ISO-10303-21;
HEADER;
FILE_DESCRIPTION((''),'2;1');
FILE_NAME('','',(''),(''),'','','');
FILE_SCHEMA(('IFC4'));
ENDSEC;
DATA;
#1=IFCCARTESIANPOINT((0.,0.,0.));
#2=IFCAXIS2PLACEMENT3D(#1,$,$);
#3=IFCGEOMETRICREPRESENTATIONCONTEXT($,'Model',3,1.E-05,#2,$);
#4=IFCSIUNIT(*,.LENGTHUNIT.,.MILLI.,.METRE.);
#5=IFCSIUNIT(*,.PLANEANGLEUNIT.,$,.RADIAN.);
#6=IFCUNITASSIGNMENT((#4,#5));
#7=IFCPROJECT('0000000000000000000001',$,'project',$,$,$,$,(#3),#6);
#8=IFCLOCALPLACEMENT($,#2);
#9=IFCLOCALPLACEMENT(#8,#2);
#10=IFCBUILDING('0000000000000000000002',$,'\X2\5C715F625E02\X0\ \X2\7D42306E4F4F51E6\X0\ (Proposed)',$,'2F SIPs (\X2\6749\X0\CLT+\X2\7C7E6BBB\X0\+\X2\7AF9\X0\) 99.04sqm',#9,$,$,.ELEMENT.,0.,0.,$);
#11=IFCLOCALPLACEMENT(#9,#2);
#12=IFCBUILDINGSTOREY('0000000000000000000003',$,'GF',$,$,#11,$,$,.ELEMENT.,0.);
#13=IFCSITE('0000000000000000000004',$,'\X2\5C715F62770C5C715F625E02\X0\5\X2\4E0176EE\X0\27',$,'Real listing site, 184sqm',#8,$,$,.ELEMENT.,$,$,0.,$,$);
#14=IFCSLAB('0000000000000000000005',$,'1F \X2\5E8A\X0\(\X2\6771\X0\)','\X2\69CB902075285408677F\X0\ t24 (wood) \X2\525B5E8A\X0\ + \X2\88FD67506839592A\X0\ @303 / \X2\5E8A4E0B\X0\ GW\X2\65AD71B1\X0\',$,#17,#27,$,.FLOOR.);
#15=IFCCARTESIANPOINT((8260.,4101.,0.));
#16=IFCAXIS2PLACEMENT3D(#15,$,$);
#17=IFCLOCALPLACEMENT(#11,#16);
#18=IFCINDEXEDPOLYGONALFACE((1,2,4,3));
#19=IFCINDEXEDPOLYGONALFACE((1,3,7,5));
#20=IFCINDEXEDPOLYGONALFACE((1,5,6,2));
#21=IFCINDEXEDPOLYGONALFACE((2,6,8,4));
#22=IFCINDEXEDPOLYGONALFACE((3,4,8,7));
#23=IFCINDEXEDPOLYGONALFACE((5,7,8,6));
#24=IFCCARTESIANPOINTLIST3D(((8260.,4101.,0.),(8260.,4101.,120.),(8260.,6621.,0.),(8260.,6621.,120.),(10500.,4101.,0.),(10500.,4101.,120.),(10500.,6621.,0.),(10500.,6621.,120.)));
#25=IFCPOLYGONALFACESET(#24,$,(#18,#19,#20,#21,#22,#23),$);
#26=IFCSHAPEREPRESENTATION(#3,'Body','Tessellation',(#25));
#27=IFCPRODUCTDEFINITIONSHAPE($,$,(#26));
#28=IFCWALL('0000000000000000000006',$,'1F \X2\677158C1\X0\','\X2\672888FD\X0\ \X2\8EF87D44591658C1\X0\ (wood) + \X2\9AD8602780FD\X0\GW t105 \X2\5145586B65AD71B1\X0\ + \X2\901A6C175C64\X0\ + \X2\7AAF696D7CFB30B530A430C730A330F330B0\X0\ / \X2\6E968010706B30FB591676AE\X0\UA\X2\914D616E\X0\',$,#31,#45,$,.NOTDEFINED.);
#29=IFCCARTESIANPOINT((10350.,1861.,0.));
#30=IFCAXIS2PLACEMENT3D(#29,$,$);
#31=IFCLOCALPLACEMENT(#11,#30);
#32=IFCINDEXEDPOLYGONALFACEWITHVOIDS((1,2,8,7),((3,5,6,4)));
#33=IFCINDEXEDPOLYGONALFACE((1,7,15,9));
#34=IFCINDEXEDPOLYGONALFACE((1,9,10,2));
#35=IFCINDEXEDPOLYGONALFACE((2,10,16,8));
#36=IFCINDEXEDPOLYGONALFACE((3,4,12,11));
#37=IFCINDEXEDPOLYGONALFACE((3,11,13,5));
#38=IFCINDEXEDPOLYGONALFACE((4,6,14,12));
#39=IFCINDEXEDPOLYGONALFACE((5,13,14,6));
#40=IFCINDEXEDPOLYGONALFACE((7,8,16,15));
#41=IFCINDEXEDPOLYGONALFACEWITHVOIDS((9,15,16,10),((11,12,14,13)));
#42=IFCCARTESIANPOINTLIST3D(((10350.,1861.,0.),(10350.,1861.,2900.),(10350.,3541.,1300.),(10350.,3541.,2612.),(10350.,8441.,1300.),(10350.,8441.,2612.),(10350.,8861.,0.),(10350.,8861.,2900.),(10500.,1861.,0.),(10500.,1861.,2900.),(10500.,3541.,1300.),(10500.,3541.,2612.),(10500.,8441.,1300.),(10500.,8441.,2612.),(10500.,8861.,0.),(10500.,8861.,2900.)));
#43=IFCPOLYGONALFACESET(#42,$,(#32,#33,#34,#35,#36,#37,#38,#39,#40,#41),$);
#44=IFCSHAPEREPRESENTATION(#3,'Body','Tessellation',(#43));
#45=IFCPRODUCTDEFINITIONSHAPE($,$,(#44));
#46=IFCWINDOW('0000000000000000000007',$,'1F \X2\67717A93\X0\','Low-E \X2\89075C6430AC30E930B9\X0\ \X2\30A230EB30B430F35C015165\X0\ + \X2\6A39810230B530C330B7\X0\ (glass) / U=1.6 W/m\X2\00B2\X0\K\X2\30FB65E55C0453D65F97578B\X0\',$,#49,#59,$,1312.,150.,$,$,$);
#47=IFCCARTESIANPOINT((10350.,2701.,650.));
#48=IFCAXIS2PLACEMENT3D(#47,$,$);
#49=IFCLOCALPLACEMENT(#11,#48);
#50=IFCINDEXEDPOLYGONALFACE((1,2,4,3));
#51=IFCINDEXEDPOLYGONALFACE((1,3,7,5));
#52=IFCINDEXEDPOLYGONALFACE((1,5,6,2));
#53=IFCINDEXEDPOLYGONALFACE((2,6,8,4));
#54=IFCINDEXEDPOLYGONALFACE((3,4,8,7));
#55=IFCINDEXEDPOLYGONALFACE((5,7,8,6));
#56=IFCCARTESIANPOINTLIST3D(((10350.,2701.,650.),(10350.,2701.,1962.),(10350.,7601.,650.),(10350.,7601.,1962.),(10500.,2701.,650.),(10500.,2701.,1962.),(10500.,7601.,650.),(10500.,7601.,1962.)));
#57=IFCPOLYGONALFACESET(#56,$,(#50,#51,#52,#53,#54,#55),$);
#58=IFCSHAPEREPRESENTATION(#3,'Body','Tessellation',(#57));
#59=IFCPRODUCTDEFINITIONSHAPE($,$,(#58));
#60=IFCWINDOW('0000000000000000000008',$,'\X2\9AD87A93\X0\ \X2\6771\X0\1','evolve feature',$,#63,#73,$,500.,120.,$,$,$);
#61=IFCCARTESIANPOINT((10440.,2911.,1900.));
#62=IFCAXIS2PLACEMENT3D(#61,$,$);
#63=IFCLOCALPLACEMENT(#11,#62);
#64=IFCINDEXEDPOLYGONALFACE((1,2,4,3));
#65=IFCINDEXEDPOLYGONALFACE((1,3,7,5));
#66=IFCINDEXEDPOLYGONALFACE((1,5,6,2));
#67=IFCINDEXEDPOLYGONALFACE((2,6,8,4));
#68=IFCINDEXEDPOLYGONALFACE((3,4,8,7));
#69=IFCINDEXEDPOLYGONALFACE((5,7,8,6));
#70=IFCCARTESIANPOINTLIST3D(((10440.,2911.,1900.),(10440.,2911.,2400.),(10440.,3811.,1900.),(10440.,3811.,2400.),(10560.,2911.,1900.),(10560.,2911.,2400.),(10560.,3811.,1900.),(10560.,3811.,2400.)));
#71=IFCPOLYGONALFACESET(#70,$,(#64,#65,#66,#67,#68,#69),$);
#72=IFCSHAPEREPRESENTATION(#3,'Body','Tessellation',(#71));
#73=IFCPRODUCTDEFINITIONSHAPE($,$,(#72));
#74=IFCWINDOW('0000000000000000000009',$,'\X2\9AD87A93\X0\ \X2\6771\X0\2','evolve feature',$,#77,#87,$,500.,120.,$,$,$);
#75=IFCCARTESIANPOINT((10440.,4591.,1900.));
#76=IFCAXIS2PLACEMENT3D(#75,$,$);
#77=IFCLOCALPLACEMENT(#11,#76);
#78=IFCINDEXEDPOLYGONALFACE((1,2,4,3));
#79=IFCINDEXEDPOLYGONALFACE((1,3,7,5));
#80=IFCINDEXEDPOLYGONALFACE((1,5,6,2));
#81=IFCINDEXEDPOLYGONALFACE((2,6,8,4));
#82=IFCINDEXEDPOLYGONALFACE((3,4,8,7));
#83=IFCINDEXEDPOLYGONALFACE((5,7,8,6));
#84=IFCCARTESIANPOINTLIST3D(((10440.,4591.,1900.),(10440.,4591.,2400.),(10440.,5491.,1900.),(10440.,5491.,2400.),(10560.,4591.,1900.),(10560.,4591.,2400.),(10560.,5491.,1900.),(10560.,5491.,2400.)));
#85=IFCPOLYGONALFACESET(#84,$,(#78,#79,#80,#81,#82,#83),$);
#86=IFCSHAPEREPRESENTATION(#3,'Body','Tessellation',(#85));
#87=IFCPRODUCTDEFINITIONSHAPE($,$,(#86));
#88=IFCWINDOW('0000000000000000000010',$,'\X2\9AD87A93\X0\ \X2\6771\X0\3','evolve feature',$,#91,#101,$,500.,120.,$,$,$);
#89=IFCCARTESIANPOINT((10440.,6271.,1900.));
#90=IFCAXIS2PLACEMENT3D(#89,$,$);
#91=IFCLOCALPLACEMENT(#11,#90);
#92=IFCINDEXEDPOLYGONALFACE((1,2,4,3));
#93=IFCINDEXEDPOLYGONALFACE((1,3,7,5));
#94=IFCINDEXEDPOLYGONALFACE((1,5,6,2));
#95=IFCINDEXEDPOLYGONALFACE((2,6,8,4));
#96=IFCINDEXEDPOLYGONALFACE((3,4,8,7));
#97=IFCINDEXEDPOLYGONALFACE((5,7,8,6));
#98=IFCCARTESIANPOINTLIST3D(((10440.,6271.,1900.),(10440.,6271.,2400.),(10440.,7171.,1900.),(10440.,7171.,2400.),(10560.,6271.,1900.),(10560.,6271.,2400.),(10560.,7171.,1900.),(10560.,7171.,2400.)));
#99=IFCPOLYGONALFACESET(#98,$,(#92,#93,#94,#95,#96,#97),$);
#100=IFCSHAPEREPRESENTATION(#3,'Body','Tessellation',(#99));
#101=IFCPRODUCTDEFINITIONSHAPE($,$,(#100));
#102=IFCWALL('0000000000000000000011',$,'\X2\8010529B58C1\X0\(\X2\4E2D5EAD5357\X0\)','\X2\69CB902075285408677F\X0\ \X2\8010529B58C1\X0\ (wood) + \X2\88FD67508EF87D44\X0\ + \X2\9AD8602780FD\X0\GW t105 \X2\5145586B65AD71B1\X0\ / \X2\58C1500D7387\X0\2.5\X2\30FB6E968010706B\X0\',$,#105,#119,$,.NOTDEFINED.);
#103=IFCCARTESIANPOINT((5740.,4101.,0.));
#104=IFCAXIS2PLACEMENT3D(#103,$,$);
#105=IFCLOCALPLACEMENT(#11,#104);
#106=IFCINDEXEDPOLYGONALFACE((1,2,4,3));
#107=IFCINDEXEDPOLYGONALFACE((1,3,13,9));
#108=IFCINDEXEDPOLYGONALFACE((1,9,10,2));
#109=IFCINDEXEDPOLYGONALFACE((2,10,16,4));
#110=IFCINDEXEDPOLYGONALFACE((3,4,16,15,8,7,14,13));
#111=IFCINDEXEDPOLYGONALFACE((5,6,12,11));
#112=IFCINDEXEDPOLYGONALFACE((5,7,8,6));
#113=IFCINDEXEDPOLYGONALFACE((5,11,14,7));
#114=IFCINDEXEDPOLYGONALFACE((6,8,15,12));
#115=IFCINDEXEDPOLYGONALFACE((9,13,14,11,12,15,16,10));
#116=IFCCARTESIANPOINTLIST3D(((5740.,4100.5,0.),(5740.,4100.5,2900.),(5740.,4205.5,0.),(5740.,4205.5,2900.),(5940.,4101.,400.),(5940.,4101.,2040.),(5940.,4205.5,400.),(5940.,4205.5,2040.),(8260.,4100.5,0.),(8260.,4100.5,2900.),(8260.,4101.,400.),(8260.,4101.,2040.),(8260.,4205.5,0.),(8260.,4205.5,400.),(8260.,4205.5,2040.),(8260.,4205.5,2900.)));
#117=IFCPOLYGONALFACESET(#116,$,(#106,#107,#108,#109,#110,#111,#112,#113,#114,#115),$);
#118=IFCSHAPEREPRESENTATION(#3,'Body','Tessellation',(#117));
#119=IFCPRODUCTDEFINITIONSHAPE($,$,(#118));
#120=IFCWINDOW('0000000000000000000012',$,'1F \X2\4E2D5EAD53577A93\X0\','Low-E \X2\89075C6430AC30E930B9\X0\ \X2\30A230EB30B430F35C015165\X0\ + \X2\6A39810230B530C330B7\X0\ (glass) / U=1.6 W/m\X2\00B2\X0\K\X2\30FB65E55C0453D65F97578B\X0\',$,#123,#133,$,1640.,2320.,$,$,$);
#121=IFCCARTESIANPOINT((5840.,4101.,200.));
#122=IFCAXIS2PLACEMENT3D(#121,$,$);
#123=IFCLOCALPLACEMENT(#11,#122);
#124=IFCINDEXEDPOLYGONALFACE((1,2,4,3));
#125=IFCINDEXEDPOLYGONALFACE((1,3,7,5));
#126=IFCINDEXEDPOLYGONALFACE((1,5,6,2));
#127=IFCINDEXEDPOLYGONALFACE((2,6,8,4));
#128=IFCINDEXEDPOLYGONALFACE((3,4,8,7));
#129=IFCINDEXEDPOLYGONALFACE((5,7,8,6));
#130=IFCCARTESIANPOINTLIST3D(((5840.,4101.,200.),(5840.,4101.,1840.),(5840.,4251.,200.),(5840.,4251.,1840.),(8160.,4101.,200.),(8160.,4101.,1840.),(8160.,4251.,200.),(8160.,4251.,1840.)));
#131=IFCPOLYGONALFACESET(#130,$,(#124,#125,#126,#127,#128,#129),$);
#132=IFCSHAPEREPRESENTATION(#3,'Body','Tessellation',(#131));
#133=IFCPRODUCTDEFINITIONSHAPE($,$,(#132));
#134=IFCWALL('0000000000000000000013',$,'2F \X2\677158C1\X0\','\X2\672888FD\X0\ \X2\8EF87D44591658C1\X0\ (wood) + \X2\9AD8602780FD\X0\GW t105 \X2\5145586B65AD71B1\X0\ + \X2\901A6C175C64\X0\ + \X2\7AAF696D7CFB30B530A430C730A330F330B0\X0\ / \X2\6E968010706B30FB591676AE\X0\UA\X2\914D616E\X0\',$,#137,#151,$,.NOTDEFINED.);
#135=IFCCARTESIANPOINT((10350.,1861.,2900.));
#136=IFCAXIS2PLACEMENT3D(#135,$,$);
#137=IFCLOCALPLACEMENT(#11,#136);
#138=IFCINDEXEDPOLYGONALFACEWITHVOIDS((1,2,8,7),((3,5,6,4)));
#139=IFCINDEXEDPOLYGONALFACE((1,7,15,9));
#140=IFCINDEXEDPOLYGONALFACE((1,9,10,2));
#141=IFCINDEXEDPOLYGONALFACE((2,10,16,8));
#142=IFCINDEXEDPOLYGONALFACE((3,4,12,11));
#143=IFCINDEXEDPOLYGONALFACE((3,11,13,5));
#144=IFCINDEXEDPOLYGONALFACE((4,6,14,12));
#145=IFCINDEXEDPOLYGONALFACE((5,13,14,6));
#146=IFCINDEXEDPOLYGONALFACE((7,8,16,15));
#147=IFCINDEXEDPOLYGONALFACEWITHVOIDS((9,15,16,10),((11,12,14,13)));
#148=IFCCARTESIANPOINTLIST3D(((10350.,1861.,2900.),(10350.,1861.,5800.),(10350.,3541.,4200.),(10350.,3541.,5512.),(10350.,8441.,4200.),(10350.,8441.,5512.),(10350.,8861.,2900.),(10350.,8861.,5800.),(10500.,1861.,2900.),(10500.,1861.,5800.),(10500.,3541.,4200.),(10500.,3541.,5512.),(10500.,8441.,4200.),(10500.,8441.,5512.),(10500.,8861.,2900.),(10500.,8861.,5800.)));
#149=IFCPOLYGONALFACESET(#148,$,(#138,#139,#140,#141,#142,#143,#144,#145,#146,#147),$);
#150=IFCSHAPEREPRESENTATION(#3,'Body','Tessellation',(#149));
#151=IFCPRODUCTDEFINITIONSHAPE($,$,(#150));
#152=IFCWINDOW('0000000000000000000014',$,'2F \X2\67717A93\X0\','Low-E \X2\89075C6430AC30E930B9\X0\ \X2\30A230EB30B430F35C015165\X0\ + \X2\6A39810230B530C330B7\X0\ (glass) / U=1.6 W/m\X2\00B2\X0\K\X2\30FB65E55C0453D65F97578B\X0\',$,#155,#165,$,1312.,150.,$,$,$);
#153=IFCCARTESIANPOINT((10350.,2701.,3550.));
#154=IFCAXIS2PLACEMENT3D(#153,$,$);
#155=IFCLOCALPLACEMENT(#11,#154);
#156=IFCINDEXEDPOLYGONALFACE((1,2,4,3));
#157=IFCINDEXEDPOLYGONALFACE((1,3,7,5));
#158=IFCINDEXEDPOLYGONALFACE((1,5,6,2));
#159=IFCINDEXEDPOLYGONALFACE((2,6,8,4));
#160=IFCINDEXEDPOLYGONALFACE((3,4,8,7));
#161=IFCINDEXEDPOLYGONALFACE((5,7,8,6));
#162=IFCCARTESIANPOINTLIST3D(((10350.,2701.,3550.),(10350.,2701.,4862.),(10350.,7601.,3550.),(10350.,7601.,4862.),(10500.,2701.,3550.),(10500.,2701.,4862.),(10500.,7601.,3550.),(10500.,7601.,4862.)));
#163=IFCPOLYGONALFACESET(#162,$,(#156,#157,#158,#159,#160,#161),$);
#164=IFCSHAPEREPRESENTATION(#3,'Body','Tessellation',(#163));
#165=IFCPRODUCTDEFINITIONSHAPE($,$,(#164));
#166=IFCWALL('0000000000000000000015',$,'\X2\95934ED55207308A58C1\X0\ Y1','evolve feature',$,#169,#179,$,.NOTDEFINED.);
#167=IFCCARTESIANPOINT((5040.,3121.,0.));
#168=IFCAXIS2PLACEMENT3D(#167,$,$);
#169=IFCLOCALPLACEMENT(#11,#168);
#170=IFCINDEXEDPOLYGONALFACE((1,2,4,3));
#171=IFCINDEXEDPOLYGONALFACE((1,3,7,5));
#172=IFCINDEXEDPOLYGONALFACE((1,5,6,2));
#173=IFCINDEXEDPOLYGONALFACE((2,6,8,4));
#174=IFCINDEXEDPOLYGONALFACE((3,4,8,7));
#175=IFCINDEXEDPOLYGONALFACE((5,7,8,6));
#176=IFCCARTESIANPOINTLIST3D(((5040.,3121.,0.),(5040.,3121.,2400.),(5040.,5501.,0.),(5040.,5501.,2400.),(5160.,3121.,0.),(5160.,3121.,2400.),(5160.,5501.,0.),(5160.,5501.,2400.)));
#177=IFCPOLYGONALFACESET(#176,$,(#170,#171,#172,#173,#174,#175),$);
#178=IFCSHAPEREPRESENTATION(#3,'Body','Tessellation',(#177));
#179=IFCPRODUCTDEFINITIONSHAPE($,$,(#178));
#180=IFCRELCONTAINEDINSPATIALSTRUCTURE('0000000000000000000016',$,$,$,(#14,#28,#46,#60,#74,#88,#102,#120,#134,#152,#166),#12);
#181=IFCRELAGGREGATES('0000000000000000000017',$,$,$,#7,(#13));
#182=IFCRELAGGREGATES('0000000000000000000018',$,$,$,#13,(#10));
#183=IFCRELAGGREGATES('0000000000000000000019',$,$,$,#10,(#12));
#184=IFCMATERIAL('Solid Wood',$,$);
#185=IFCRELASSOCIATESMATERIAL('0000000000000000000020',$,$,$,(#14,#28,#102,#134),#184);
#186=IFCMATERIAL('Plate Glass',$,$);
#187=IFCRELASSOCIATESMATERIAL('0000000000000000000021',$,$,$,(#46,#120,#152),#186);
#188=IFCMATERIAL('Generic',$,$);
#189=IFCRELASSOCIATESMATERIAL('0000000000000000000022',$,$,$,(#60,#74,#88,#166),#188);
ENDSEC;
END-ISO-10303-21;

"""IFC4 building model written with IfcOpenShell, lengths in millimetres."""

from ifc_helpers import new_model, si_unit, frame, frame_2d, origin, place, context, project, spatial, rectangle, extrude, material, element, fill, save


model = new_model("IFC4")

# Units and contexts
model_context = context("Model", 3, precision=1e-05, world=origin())
ifc_project = project(units=[si_unit("LENGTHUNIT", "METRE", prefix="MILLI"), si_unit("PLANEANGLEUNIT", "RADIAN")], contexts=[model_context])

# Site, building, storey
site_placement = place(None, origin())
site = spatial("IfcSite", under=ifc_project, at=site_placement, Name="山形県山形市5丁目27", ObjectType="Real listing site, 184sqm", CompositionType="ELEMENT", RefElevation=0.0)
building_placement = place(site_placement, origin())
building = spatial("IfcBuilding", under=site, at=building_placement, Name="山形市 終の住処 (Proposed)", ObjectType="2F SIPs (杉CLT+籾殻+竹) 99.04sqm", CompositionType="ELEMENT", ElevationOfRefHeight=0.0, ElevationOfTerrain=0.0)
storey_placement = place(building_placement, origin())
storey = spatial("IfcBuildingStorey", under=building, at=storey_placement, Name="GF", CompositionType="ELEMENT", Elevation=0.0)

# Slab
ifc_material_1 = material(Name="Solid Wood")
slab_placement = place(storey_placement, frame((8260.0, 4101.0, 0.0)))
element("IfcSlab", 1, at=slab_placement, inside=storey, material=ifc_material_1, Name="1F 床(東)", Description="構造用合板 t24 (wood) 剛床 + 製材根太 @303 / 床下 GW断熱", PredefinedType="FLOOR", context=model_context, shape_type="SweptSolid", body=[
    extrude(rectangle(XDim=2240.0, YDim=2520.0, at=frame_2d((1120.0, 1260.0))), frame((8260.0, 4101.0, 0.0)), (0.0, 0.0, 1.0), 120.0),
])

# Wall, openings, windows
wall_1_placement = place(storey_placement, frame((10350.0, 1861.0, 0.0)))
wall_1 = element("IfcWall", 2, at=wall_1_placement, inside=storey, material=ifc_material_1, Name="1F 東壁", Description="木製 軸組外壁 (wood) + 高性能GW t105 充填断熱 + 通気層 + 窯業系サイディング / 準耐火・外皮UA配慮", PredefinedType="NOTDEFINED", context=model_context, shape_type="SweptSolid", body=[
    extrude(rectangle(XDim=150.0, YDim=7000.0, at=frame_2d((75.0, 3500.0))), frame((10350.0, 1861.0, 0.0)), (0.0, 0.0, 1.0), 2900.0),
])
opening_1_placement = place(storey_placement, frame((10350.0, 2701.0, 650.0)))
opening_1 = element("IfcOpeningElement", 3, at=opening_1_placement, cuts=wall_1, PredefinedType="NOTDEFINED", context=model_context, shape_type="SweptSolid", body=[
    extrude(rectangle(XDim=150.0, YDim=4900.0, at=frame_2d((75.0, 2450.0))), frame((10350.0, 2701.0, 650.0)), (0.0, 0.0, 1.0), 1312.0),
])
opening_2_placement = place(storey_placement, frame((10440.0, 2911.0, 1900.0)))
opening_2 = element("IfcOpeningElement", 4, at=opening_2_placement, cuts=wall_1, PredefinedType="NOTDEFINED", context=model_context, shape_type="SweptSolid", body=[
    extrude(rectangle(XDim=120.0, YDim=900.0, at=frame_2d((60.0, 450.0))), frame((10440.0, 2911.0, 1900.0)), (0.0, 0.0, 1.0), 500.0),
])
opening_3_placement = place(storey_placement, frame((10440.0, 4591.0, 1900.0)))
opening_3 = element("IfcOpeningElement", 5, at=opening_3_placement, cuts=wall_1, PredefinedType="NOTDEFINED", context=model_context, shape_type="SweptSolid", body=[
    extrude(rectangle(XDim=120.0, YDim=900.0, at=frame_2d((60.0, 450.0))), frame((10440.0, 4591.0, 1900.0)), (0.0, 0.0, 1.0), 500.0),
])
opening_4_placement = place(storey_placement, frame((10440.0, 6271.0, 1900.0)))
opening_4 = element("IfcOpeningElement", 6, at=opening_4_placement, cuts=wall_1, PredefinedType="NOTDEFINED", context=model_context, shape_type="SweptSolid", body=[
    extrude(rectangle(XDim=120.0, YDim=900.0, at=frame_2d((60.0, 450.0))), frame((10440.0, 6271.0, 1900.0)), (0.0, 0.0, 1.0), 500.0),
])
ifc_material_2 = material(Name="Plate Glass")
window_1_placement = place(storey_placement, frame((10350.0, 2701.0, 650.0)))
window_1 = element("IfcWindow", 7, at=window_1_placement, inside=storey, material=ifc_material_2, Name="1F 東窓", Description="Low-E 複層ガラス アルゴン封入 + 樹脂サッシ (glass) / U=1.6 W/m²K・日射取得型", OverallHeight=1312.0, OverallWidth=150.0, context=model_context, shape_type="SweptSolid", body=[
    extrude(rectangle(XDim=150.0, YDim=4900.0, at=frame_2d((75.0, 2450.0))), frame((10350.0, 2701.0, 650.0)), (0.0, 0.0, 1.0), 1312.0),
])
fill(opening_1, window_1)
ifc_material_3 = material(Name="Generic")
window_2_placement = place(storey_placement, frame((10440.0, 2911.0, 1900.0)))
window_2 = element("IfcWindow", 8, at=window_2_placement, inside=storey, material=ifc_material_3, Name="高窓 東1", Description="evolve feature", OverallHeight=500.0, OverallWidth=120.0, context=model_context, shape_type="SweptSolid", body=[
    extrude(rectangle(XDim=120.0, YDim=900.0, at=frame_2d((60.0, 450.0))), frame((10440.0, 2911.0, 1900.0)), (0.0, 0.0, 1.0), 500.0),
])
fill(opening_2, window_2)
window_3_placement = place(storey_placement, frame((10440.0, 4591.0, 1900.0)))
window_3 = element("IfcWindow", 9, at=window_3_placement, inside=storey, material=ifc_material_3, Name="高窓 東2", Description="evolve feature", OverallHeight=500.0, OverallWidth=120.0, context=model_context, shape_type="SweptSolid", body=[
    extrude(rectangle(XDim=120.0, YDim=900.0, at=frame_2d((60.0, 450.0))), frame((10440.0, 4591.0, 1900.0)), (0.0, 0.0, 1.0), 500.0),
])
fill(opening_3, window_3)
window_4_placement = place(storey_placement, frame((10440.0, 6271.0, 1900.0)))
window_4 = element("IfcWindow", 10, at=window_4_placement, inside=storey, material=ifc_material_3, Name="高窓 東3", Description="evolve feature", OverallHeight=500.0, OverallWidth=120.0, context=model_context, shape_type="SweptSolid", body=[
    extrude(rectangle(XDim=120.0, YDim=900.0, at=frame_2d((60.0, 450.0))), frame((10440.0, 6271.0, 1900.0)), (0.0, 0.0, 1.0), 500.0),
])
fill(opening_4, window_4)

# Wall, opening, window
wall_2_placement = place(storey_placement, frame((5740.0, 4101.0, 0.0)))
wall_2 = element("IfcWall", 11, at=wall_2_placement, inside=storey, material=ifc_material_1, Name="耐力壁(中庭南)", Description="構造用合板 耐力壁 (wood) + 製材軸組 + 高性能GW t105 充填断熱 / 壁倍率2.5・準耐火", PredefinedType="NOTDEFINED", context=model_context, shape_type="SweptSolid", body=[
    extrude(rectangle(XDim=2520.0, YDim=105.0, at=frame_2d((1260.0, 52.0))), frame((5740.0, 4101.0, 0.0)), (0.0, 0.0, 1.0), 2900.0),
])
opening_5_placement = place(storey_placement, frame((5840.0, 4101.0, 200.0)))
opening_5 = element("IfcOpeningElement", 12, at=opening_5_placement, cuts=wall_2, PredefinedType="NOTDEFINED", context=model_context, shape_type="SweptSolid", body=[
    extrude(rectangle(XDim=2320.0, YDim=150.0, at=frame_2d((1160.0, 75.0))), frame((5840.0, 4101.0, 200.0)), (0.0, 0.0, 1.0), 1640.0),
])
window_5_placement = place(storey_placement, frame((5840.0, 4101.0, 200.0)))
window_5 = element("IfcWindow", 13, at=window_5_placement, inside=storey, material=ifc_material_2, Name="1F 中庭南窓", Description="Low-E 複層ガラス アルゴン封入 + 樹脂サッシ (glass) / U=1.6 W/m²K・日射取得型", OverallHeight=1640.0, OverallWidth=2320.0, context=model_context, shape_type="SweptSolid", body=[
    extrude(rectangle(XDim=2320.0, YDim=150.0, at=frame_2d((1160.0, 75.0))), frame((5840.0, 4101.0, 200.0)), (0.0, 0.0, 1.0), 1640.0),
])
fill(opening_5, window_5)

# Wall, opening, window
wall_3_placement = place(storey_placement, frame((10350.0, 1861.0, 2900.0)))
wall_3 = element("IfcWall", 14, at=wall_3_placement, inside=storey, material=ifc_material_1, Name="2F 東壁", Description="木製 軸組外壁 (wood) + 高性能GW t105 充填断熱 + 通気層 + 窯業系サイディング / 準耐火・外皮UA配慮", PredefinedType="NOTDEFINED", context=model_context, shape_type="SweptSolid", body=[
    extrude(rectangle(XDim=150.0, YDim=7000.0, at=frame_2d((75.0, 3500.0))), frame((10350.0, 1861.0, 2900.0)), (0.0, 0.0, 1.0), 2900.0),
])
opening_6_placement = place(storey_placement, frame((10350.0, 2701.0, 3550.0)))
opening_6 = element("IfcOpeningElement", 15, at=opening_6_placement, cuts=wall_3, PredefinedType="NOTDEFINED", context=model_context, shape_type="SweptSolid", body=[
    extrude(rectangle(XDim=150.0, YDim=4900.0, at=frame_2d((75.0, 2450.0))), frame((10350.0, 2701.0, 3550.0)), (0.0, 0.0, 1.0), 1312.0),
])
window_6_placement = place(storey_placement, frame((10350.0, 2701.0, 3550.0)))
window_6 = element("IfcWindow", 16, at=window_6_placement, inside=storey, material=ifc_material_2, Name="2F 東窓", Description="Low-E 複層ガラス アルゴン封入 + 樹脂サッシ (glass) / U=1.6 W/m²K・日射取得型", OverallHeight=1312.0, OverallWidth=150.0, context=model_context, shape_type="SweptSolid", body=[
    extrude(rectangle(XDim=150.0, YDim=4900.0, at=frame_2d((75.0, 2450.0))), frame((10350.0, 2701.0, 3550.0)), (0.0, 0.0, 1.0), 1312.0),
])
fill(opening_6, window_6)

# Wall
wall_4_placement = place(storey_placement, frame((5040.0, 3121.0, 0.0)))
element("IfcWall", 17, at=wall_4_placement, inside=storey, material=ifc_material_3, Name="間仕切り壁 Y1", Description="evolve feature", PredefinedType="NOTDEFINED", context=model_context, shape_type="SweptSolid", body=[
    extrude(rectangle(XDim=120.0, YDim=2380.0, at=frame_2d((60.0, 1190.0))), frame((5040.0, 3121.0, 0.0)), (0.0, 0.0, 1.0), 2400.0),
])

save(model, "model.ifc")
